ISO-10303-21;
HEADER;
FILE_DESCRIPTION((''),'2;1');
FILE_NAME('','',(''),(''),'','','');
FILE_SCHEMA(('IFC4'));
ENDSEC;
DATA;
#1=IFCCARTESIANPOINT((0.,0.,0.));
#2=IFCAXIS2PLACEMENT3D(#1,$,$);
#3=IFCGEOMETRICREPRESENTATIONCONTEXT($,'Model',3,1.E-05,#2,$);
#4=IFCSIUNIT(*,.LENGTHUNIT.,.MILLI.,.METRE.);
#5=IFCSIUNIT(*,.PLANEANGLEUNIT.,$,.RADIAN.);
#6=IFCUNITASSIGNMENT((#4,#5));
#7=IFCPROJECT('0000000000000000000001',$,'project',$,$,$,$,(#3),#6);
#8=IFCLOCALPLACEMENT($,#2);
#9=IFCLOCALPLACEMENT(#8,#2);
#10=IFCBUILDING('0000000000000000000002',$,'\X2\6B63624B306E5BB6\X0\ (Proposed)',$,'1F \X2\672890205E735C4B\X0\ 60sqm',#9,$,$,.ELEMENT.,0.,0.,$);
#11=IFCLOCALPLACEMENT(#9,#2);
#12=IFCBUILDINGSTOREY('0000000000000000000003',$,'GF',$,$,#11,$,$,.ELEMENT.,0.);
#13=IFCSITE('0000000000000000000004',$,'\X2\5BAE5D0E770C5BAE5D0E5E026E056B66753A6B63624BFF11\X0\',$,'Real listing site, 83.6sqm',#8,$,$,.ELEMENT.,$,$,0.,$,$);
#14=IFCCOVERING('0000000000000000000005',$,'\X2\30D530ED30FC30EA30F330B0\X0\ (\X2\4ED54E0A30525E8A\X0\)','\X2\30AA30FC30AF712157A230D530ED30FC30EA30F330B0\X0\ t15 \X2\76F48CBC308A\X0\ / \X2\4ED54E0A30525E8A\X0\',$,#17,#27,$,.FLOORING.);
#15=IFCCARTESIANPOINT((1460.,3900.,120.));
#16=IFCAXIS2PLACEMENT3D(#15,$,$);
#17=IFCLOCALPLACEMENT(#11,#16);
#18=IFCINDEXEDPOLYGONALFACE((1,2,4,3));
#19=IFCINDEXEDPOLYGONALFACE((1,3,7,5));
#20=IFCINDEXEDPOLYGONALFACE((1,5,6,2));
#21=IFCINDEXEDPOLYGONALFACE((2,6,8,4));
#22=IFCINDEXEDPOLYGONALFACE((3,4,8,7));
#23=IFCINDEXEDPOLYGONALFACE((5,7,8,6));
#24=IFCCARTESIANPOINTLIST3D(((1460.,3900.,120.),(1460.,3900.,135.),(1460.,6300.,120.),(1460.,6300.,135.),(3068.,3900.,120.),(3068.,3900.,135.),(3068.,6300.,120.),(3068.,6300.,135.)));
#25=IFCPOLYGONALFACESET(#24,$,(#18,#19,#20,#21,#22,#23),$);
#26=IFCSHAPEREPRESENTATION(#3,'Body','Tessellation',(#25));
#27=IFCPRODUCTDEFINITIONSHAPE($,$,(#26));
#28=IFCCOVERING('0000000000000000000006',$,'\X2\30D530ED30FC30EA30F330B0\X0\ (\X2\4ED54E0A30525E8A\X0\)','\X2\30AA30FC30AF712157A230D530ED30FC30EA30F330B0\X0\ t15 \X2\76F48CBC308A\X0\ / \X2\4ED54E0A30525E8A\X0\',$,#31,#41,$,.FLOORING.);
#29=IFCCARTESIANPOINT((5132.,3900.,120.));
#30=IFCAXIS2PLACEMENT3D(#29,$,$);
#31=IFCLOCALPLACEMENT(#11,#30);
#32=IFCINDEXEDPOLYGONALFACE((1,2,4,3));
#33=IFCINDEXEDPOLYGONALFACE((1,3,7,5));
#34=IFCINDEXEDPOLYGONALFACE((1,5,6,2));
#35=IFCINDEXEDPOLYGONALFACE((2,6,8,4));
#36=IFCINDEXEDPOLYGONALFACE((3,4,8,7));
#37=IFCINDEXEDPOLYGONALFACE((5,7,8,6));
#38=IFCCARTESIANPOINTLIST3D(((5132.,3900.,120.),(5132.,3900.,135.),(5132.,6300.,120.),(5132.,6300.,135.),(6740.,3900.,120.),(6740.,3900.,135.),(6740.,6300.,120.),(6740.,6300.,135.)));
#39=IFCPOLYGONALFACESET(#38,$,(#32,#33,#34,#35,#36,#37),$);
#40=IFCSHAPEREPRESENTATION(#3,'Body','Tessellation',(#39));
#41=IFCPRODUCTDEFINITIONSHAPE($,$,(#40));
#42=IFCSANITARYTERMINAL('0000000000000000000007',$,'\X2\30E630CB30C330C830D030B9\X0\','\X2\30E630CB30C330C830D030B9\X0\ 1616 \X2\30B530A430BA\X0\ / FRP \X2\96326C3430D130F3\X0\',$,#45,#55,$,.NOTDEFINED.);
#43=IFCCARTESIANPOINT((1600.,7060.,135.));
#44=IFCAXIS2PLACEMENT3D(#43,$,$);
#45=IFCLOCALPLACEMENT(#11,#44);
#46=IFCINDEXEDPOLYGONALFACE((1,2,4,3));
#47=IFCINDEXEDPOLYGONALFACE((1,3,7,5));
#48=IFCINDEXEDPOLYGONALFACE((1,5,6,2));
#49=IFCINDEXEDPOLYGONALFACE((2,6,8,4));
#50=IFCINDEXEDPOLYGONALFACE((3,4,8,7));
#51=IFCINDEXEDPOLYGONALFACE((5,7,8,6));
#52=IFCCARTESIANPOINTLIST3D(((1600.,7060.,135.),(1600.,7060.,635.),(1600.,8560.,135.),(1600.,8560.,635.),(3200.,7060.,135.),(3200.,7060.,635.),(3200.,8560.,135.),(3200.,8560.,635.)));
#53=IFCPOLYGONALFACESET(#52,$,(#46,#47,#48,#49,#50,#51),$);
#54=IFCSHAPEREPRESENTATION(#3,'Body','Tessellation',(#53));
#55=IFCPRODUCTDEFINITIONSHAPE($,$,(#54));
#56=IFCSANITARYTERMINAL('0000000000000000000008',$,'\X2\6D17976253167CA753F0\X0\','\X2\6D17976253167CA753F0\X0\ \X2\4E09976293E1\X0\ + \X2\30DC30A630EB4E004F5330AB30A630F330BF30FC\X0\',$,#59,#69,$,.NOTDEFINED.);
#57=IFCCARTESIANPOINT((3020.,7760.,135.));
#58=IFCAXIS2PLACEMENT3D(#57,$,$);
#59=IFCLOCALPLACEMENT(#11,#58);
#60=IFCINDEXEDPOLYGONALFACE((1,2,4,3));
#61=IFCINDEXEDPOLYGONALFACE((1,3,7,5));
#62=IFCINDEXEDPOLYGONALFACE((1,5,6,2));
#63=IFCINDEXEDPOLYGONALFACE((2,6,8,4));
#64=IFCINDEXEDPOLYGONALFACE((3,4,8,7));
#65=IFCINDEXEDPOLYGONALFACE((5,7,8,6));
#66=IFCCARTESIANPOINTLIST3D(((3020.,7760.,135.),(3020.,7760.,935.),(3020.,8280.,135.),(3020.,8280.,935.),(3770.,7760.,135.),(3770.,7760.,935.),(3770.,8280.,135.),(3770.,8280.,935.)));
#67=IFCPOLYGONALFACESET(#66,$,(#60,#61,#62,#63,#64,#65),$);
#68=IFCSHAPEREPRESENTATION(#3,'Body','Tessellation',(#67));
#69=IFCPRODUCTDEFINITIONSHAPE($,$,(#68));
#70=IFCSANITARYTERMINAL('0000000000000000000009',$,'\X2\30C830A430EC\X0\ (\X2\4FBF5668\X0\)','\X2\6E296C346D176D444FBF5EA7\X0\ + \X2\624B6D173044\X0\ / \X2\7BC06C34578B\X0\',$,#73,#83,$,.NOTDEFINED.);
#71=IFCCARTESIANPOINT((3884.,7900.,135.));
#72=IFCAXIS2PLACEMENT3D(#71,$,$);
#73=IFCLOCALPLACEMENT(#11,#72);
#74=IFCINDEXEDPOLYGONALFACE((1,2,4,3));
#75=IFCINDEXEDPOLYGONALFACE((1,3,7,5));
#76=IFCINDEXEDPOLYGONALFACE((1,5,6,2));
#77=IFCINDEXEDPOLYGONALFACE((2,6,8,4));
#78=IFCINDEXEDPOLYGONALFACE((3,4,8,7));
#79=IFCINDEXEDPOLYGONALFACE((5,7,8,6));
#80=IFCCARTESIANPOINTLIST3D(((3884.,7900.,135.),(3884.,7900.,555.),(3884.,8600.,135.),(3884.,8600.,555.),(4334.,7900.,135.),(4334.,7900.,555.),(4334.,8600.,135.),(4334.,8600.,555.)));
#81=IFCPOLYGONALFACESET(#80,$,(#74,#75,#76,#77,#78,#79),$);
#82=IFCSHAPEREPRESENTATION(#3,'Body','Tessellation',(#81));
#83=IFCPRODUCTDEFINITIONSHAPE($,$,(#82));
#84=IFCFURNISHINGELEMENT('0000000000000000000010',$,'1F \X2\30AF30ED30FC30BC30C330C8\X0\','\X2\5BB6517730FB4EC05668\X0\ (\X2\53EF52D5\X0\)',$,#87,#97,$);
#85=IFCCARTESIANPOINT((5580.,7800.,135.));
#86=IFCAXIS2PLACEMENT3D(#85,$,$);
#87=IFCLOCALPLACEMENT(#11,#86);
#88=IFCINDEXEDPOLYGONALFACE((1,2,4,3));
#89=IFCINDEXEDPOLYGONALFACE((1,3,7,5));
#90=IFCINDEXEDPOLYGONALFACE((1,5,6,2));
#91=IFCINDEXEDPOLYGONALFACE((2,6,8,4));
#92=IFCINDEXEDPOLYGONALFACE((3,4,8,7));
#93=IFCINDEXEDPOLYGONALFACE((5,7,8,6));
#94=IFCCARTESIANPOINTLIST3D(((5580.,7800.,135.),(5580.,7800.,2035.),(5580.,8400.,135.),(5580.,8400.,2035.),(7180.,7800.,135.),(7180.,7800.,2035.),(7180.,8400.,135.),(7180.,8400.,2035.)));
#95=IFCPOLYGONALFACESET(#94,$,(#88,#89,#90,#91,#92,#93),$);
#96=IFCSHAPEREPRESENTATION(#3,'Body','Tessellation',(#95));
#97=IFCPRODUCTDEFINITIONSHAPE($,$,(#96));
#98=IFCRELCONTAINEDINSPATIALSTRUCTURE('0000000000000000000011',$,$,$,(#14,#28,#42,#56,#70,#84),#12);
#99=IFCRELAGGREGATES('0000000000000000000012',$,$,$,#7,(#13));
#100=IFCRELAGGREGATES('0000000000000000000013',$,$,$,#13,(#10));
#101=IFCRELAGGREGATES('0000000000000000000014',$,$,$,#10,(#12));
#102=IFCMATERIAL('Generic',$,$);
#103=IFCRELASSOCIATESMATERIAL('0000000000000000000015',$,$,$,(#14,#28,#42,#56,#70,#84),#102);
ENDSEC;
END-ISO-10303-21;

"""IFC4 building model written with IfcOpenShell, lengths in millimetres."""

from ifc_helpers import new_model, si_unit, frame, frame_2d, origin, place, context, project, spatial, rectangle, extrude, material, element, save


model = new_model("IFC4")

# Units and contexts
model_context = context("Model", 3, precision=1e-05, world=origin())
ifc_project = project(units=[si_unit("LENGTHUNIT", "METRE", prefix="MILLI"), si_unit("PLANEANGLEUNIT", "RADIAN")], contexts=[model_context])

# Site, building, storey
site_placement = place(None, origin())
site = spatial("IfcSite", under=ifc_project, at=site_placement, Name="宮崎県宮崎市清武町正手１", ObjectType="Real listing site, 83.6sqm", CompositionType="ELEMENT", RefElevation=0.0)
building_placement = place(site_placement, origin())
building = spatial("IfcBuilding", under=site, at=building_placement, Name="正手の家 (Proposed)", ObjectType="1F 木造平屋 60sqm", CompositionType="ELEMENT", ElevationOfRefHeight=0.0, ElevationOfTerrain=0.0)
storey_placement = place(building_placement, origin())
storey = spatial("IfcBuildingStorey", under=building, at=storey_placement, Name="GF", CompositionType="ELEMENT", Elevation=0.0)

# Coverings
ifc_material_1 = material(Name="Generic")
covering_1_placement = place(storey_placement, frame((1460.0, 3900.0, 120.0)))
element("IfcCovering", 1, at=covering_1_placement, inside=storey, material=ifc_material_1, Name="フローリング (仕上げ床)", Description="オーク無垢フローリング t15 直貼り / 仕上げ床", PredefinedType="FLOORING", context=model_context, shape_type="SweptSolid", body=[
    extrude(rectangle(XDim=1608.0, YDim=2400.0, at=frame_2d((804.0, 1200.0))), frame((1460.0, 3900.0, 120.0)), (0.0, 0.0, 1.0), 15.0),
])
covering_2_placement = place(storey_placement, frame((5132.0, 3900.0, 120.0)))
element("IfcCovering", 2, at=covering_2_placement, inside=storey, material=ifc_material_1, Name="フローリング (仕上げ床)", Description="オーク無垢フローリング t15 直貼り / 仕上げ床", PredefinedType="FLOORING", context=model_context, shape_type="SweptSolid", body=[
    extrude(rectangle(XDim=1608.0, YDim=2400.0, at=frame_2d((804.0, 1200.0))), frame((5132.0, 3900.0, 120.0)), (0.0, 0.0, 1.0), 15.0),
])

# Sanitary terminals
sanitary_terminal_1_placement = place(storey_placement, frame((1600.0, 7060.0, 135.0)))
element("IfcSanitaryTerminal", 3, at=sanitary_terminal_1_placement, inside=storey, material=ifc_material_1, Name="ユニットバス", Description="ユニットバス 1616 サイズ / FRP 防水パン", PredefinedType="NOTDEFINED", context=model_context, shape_type="SweptSolid", body=[
    extrude(rectangle(XDim=1600.0, YDim=1500.0, at=frame_2d((800.0, 750.0))), frame((1600.0, 7060.0, 135.0)), (0.0, 0.0, 1.0), 500.0),
])
sanitary_terminal_2_placement = place(storey_placement, frame((3020.0, 7760.0, 135.0)))
element("IfcSanitaryTerminal", 4, at=sanitary_terminal_2_placement, inside=storey, material=ifc_material_1, Name="洗面化粧台", Description="洗面化粧台 三面鏡 + ボウル一体カウンター", PredefinedType="NOTDEFINED", context=model_context, shape_type="SweptSolid", body=[
    extrude(rectangle(XDim=750.0, YDim=520.0, at=frame_2d((375.0, 260.0))), frame((3020.0, 7760.0, 135.0)), (0.0, 0.0, 1.0), 800.0),
])
sanitary_terminal_3_placement = place(storey_placement, frame((3884.0, 7900.0, 135.0)))
element("IfcSanitaryTerminal", 5, at=sanitary_terminal_3_placement, inside=storey, material=ifc_material_1, Name="トイレ (便器)", Description="温水洗浄便座 + 手洗い / 節水型", PredefinedType="NOTDEFINED", context=model_context, shape_type="SweptSolid", body=[
    extrude(rectangle(XDim=450.0, YDim=700.0, at=frame_2d((225.0, 350.0))), frame((3884.0, 7900.0, 135.0)), (0.0, 0.0, 1.0), 420.0),
])

# Furnishing element
furnishing_placement = place(storey_placement, frame((5580.0, 7800.0, 135.0)))
element("IfcFurnishingElement", 6, at=furnishing_placement, inside=storey, material=ifc_material_1, Name="1F クローゼット", Description="家具・什器 (可動)", context=model_context, shape_type="SweptSolid", body=[
    extrude(rectangle(XDim=1600.0, YDim=600.0, at=frame_2d((800.0, 300.0))), frame((5580.0, 7800.0, 135.0)), (0.0, 0.0, 1.0), 1900.0),
])

save(model, "model.ifc")
